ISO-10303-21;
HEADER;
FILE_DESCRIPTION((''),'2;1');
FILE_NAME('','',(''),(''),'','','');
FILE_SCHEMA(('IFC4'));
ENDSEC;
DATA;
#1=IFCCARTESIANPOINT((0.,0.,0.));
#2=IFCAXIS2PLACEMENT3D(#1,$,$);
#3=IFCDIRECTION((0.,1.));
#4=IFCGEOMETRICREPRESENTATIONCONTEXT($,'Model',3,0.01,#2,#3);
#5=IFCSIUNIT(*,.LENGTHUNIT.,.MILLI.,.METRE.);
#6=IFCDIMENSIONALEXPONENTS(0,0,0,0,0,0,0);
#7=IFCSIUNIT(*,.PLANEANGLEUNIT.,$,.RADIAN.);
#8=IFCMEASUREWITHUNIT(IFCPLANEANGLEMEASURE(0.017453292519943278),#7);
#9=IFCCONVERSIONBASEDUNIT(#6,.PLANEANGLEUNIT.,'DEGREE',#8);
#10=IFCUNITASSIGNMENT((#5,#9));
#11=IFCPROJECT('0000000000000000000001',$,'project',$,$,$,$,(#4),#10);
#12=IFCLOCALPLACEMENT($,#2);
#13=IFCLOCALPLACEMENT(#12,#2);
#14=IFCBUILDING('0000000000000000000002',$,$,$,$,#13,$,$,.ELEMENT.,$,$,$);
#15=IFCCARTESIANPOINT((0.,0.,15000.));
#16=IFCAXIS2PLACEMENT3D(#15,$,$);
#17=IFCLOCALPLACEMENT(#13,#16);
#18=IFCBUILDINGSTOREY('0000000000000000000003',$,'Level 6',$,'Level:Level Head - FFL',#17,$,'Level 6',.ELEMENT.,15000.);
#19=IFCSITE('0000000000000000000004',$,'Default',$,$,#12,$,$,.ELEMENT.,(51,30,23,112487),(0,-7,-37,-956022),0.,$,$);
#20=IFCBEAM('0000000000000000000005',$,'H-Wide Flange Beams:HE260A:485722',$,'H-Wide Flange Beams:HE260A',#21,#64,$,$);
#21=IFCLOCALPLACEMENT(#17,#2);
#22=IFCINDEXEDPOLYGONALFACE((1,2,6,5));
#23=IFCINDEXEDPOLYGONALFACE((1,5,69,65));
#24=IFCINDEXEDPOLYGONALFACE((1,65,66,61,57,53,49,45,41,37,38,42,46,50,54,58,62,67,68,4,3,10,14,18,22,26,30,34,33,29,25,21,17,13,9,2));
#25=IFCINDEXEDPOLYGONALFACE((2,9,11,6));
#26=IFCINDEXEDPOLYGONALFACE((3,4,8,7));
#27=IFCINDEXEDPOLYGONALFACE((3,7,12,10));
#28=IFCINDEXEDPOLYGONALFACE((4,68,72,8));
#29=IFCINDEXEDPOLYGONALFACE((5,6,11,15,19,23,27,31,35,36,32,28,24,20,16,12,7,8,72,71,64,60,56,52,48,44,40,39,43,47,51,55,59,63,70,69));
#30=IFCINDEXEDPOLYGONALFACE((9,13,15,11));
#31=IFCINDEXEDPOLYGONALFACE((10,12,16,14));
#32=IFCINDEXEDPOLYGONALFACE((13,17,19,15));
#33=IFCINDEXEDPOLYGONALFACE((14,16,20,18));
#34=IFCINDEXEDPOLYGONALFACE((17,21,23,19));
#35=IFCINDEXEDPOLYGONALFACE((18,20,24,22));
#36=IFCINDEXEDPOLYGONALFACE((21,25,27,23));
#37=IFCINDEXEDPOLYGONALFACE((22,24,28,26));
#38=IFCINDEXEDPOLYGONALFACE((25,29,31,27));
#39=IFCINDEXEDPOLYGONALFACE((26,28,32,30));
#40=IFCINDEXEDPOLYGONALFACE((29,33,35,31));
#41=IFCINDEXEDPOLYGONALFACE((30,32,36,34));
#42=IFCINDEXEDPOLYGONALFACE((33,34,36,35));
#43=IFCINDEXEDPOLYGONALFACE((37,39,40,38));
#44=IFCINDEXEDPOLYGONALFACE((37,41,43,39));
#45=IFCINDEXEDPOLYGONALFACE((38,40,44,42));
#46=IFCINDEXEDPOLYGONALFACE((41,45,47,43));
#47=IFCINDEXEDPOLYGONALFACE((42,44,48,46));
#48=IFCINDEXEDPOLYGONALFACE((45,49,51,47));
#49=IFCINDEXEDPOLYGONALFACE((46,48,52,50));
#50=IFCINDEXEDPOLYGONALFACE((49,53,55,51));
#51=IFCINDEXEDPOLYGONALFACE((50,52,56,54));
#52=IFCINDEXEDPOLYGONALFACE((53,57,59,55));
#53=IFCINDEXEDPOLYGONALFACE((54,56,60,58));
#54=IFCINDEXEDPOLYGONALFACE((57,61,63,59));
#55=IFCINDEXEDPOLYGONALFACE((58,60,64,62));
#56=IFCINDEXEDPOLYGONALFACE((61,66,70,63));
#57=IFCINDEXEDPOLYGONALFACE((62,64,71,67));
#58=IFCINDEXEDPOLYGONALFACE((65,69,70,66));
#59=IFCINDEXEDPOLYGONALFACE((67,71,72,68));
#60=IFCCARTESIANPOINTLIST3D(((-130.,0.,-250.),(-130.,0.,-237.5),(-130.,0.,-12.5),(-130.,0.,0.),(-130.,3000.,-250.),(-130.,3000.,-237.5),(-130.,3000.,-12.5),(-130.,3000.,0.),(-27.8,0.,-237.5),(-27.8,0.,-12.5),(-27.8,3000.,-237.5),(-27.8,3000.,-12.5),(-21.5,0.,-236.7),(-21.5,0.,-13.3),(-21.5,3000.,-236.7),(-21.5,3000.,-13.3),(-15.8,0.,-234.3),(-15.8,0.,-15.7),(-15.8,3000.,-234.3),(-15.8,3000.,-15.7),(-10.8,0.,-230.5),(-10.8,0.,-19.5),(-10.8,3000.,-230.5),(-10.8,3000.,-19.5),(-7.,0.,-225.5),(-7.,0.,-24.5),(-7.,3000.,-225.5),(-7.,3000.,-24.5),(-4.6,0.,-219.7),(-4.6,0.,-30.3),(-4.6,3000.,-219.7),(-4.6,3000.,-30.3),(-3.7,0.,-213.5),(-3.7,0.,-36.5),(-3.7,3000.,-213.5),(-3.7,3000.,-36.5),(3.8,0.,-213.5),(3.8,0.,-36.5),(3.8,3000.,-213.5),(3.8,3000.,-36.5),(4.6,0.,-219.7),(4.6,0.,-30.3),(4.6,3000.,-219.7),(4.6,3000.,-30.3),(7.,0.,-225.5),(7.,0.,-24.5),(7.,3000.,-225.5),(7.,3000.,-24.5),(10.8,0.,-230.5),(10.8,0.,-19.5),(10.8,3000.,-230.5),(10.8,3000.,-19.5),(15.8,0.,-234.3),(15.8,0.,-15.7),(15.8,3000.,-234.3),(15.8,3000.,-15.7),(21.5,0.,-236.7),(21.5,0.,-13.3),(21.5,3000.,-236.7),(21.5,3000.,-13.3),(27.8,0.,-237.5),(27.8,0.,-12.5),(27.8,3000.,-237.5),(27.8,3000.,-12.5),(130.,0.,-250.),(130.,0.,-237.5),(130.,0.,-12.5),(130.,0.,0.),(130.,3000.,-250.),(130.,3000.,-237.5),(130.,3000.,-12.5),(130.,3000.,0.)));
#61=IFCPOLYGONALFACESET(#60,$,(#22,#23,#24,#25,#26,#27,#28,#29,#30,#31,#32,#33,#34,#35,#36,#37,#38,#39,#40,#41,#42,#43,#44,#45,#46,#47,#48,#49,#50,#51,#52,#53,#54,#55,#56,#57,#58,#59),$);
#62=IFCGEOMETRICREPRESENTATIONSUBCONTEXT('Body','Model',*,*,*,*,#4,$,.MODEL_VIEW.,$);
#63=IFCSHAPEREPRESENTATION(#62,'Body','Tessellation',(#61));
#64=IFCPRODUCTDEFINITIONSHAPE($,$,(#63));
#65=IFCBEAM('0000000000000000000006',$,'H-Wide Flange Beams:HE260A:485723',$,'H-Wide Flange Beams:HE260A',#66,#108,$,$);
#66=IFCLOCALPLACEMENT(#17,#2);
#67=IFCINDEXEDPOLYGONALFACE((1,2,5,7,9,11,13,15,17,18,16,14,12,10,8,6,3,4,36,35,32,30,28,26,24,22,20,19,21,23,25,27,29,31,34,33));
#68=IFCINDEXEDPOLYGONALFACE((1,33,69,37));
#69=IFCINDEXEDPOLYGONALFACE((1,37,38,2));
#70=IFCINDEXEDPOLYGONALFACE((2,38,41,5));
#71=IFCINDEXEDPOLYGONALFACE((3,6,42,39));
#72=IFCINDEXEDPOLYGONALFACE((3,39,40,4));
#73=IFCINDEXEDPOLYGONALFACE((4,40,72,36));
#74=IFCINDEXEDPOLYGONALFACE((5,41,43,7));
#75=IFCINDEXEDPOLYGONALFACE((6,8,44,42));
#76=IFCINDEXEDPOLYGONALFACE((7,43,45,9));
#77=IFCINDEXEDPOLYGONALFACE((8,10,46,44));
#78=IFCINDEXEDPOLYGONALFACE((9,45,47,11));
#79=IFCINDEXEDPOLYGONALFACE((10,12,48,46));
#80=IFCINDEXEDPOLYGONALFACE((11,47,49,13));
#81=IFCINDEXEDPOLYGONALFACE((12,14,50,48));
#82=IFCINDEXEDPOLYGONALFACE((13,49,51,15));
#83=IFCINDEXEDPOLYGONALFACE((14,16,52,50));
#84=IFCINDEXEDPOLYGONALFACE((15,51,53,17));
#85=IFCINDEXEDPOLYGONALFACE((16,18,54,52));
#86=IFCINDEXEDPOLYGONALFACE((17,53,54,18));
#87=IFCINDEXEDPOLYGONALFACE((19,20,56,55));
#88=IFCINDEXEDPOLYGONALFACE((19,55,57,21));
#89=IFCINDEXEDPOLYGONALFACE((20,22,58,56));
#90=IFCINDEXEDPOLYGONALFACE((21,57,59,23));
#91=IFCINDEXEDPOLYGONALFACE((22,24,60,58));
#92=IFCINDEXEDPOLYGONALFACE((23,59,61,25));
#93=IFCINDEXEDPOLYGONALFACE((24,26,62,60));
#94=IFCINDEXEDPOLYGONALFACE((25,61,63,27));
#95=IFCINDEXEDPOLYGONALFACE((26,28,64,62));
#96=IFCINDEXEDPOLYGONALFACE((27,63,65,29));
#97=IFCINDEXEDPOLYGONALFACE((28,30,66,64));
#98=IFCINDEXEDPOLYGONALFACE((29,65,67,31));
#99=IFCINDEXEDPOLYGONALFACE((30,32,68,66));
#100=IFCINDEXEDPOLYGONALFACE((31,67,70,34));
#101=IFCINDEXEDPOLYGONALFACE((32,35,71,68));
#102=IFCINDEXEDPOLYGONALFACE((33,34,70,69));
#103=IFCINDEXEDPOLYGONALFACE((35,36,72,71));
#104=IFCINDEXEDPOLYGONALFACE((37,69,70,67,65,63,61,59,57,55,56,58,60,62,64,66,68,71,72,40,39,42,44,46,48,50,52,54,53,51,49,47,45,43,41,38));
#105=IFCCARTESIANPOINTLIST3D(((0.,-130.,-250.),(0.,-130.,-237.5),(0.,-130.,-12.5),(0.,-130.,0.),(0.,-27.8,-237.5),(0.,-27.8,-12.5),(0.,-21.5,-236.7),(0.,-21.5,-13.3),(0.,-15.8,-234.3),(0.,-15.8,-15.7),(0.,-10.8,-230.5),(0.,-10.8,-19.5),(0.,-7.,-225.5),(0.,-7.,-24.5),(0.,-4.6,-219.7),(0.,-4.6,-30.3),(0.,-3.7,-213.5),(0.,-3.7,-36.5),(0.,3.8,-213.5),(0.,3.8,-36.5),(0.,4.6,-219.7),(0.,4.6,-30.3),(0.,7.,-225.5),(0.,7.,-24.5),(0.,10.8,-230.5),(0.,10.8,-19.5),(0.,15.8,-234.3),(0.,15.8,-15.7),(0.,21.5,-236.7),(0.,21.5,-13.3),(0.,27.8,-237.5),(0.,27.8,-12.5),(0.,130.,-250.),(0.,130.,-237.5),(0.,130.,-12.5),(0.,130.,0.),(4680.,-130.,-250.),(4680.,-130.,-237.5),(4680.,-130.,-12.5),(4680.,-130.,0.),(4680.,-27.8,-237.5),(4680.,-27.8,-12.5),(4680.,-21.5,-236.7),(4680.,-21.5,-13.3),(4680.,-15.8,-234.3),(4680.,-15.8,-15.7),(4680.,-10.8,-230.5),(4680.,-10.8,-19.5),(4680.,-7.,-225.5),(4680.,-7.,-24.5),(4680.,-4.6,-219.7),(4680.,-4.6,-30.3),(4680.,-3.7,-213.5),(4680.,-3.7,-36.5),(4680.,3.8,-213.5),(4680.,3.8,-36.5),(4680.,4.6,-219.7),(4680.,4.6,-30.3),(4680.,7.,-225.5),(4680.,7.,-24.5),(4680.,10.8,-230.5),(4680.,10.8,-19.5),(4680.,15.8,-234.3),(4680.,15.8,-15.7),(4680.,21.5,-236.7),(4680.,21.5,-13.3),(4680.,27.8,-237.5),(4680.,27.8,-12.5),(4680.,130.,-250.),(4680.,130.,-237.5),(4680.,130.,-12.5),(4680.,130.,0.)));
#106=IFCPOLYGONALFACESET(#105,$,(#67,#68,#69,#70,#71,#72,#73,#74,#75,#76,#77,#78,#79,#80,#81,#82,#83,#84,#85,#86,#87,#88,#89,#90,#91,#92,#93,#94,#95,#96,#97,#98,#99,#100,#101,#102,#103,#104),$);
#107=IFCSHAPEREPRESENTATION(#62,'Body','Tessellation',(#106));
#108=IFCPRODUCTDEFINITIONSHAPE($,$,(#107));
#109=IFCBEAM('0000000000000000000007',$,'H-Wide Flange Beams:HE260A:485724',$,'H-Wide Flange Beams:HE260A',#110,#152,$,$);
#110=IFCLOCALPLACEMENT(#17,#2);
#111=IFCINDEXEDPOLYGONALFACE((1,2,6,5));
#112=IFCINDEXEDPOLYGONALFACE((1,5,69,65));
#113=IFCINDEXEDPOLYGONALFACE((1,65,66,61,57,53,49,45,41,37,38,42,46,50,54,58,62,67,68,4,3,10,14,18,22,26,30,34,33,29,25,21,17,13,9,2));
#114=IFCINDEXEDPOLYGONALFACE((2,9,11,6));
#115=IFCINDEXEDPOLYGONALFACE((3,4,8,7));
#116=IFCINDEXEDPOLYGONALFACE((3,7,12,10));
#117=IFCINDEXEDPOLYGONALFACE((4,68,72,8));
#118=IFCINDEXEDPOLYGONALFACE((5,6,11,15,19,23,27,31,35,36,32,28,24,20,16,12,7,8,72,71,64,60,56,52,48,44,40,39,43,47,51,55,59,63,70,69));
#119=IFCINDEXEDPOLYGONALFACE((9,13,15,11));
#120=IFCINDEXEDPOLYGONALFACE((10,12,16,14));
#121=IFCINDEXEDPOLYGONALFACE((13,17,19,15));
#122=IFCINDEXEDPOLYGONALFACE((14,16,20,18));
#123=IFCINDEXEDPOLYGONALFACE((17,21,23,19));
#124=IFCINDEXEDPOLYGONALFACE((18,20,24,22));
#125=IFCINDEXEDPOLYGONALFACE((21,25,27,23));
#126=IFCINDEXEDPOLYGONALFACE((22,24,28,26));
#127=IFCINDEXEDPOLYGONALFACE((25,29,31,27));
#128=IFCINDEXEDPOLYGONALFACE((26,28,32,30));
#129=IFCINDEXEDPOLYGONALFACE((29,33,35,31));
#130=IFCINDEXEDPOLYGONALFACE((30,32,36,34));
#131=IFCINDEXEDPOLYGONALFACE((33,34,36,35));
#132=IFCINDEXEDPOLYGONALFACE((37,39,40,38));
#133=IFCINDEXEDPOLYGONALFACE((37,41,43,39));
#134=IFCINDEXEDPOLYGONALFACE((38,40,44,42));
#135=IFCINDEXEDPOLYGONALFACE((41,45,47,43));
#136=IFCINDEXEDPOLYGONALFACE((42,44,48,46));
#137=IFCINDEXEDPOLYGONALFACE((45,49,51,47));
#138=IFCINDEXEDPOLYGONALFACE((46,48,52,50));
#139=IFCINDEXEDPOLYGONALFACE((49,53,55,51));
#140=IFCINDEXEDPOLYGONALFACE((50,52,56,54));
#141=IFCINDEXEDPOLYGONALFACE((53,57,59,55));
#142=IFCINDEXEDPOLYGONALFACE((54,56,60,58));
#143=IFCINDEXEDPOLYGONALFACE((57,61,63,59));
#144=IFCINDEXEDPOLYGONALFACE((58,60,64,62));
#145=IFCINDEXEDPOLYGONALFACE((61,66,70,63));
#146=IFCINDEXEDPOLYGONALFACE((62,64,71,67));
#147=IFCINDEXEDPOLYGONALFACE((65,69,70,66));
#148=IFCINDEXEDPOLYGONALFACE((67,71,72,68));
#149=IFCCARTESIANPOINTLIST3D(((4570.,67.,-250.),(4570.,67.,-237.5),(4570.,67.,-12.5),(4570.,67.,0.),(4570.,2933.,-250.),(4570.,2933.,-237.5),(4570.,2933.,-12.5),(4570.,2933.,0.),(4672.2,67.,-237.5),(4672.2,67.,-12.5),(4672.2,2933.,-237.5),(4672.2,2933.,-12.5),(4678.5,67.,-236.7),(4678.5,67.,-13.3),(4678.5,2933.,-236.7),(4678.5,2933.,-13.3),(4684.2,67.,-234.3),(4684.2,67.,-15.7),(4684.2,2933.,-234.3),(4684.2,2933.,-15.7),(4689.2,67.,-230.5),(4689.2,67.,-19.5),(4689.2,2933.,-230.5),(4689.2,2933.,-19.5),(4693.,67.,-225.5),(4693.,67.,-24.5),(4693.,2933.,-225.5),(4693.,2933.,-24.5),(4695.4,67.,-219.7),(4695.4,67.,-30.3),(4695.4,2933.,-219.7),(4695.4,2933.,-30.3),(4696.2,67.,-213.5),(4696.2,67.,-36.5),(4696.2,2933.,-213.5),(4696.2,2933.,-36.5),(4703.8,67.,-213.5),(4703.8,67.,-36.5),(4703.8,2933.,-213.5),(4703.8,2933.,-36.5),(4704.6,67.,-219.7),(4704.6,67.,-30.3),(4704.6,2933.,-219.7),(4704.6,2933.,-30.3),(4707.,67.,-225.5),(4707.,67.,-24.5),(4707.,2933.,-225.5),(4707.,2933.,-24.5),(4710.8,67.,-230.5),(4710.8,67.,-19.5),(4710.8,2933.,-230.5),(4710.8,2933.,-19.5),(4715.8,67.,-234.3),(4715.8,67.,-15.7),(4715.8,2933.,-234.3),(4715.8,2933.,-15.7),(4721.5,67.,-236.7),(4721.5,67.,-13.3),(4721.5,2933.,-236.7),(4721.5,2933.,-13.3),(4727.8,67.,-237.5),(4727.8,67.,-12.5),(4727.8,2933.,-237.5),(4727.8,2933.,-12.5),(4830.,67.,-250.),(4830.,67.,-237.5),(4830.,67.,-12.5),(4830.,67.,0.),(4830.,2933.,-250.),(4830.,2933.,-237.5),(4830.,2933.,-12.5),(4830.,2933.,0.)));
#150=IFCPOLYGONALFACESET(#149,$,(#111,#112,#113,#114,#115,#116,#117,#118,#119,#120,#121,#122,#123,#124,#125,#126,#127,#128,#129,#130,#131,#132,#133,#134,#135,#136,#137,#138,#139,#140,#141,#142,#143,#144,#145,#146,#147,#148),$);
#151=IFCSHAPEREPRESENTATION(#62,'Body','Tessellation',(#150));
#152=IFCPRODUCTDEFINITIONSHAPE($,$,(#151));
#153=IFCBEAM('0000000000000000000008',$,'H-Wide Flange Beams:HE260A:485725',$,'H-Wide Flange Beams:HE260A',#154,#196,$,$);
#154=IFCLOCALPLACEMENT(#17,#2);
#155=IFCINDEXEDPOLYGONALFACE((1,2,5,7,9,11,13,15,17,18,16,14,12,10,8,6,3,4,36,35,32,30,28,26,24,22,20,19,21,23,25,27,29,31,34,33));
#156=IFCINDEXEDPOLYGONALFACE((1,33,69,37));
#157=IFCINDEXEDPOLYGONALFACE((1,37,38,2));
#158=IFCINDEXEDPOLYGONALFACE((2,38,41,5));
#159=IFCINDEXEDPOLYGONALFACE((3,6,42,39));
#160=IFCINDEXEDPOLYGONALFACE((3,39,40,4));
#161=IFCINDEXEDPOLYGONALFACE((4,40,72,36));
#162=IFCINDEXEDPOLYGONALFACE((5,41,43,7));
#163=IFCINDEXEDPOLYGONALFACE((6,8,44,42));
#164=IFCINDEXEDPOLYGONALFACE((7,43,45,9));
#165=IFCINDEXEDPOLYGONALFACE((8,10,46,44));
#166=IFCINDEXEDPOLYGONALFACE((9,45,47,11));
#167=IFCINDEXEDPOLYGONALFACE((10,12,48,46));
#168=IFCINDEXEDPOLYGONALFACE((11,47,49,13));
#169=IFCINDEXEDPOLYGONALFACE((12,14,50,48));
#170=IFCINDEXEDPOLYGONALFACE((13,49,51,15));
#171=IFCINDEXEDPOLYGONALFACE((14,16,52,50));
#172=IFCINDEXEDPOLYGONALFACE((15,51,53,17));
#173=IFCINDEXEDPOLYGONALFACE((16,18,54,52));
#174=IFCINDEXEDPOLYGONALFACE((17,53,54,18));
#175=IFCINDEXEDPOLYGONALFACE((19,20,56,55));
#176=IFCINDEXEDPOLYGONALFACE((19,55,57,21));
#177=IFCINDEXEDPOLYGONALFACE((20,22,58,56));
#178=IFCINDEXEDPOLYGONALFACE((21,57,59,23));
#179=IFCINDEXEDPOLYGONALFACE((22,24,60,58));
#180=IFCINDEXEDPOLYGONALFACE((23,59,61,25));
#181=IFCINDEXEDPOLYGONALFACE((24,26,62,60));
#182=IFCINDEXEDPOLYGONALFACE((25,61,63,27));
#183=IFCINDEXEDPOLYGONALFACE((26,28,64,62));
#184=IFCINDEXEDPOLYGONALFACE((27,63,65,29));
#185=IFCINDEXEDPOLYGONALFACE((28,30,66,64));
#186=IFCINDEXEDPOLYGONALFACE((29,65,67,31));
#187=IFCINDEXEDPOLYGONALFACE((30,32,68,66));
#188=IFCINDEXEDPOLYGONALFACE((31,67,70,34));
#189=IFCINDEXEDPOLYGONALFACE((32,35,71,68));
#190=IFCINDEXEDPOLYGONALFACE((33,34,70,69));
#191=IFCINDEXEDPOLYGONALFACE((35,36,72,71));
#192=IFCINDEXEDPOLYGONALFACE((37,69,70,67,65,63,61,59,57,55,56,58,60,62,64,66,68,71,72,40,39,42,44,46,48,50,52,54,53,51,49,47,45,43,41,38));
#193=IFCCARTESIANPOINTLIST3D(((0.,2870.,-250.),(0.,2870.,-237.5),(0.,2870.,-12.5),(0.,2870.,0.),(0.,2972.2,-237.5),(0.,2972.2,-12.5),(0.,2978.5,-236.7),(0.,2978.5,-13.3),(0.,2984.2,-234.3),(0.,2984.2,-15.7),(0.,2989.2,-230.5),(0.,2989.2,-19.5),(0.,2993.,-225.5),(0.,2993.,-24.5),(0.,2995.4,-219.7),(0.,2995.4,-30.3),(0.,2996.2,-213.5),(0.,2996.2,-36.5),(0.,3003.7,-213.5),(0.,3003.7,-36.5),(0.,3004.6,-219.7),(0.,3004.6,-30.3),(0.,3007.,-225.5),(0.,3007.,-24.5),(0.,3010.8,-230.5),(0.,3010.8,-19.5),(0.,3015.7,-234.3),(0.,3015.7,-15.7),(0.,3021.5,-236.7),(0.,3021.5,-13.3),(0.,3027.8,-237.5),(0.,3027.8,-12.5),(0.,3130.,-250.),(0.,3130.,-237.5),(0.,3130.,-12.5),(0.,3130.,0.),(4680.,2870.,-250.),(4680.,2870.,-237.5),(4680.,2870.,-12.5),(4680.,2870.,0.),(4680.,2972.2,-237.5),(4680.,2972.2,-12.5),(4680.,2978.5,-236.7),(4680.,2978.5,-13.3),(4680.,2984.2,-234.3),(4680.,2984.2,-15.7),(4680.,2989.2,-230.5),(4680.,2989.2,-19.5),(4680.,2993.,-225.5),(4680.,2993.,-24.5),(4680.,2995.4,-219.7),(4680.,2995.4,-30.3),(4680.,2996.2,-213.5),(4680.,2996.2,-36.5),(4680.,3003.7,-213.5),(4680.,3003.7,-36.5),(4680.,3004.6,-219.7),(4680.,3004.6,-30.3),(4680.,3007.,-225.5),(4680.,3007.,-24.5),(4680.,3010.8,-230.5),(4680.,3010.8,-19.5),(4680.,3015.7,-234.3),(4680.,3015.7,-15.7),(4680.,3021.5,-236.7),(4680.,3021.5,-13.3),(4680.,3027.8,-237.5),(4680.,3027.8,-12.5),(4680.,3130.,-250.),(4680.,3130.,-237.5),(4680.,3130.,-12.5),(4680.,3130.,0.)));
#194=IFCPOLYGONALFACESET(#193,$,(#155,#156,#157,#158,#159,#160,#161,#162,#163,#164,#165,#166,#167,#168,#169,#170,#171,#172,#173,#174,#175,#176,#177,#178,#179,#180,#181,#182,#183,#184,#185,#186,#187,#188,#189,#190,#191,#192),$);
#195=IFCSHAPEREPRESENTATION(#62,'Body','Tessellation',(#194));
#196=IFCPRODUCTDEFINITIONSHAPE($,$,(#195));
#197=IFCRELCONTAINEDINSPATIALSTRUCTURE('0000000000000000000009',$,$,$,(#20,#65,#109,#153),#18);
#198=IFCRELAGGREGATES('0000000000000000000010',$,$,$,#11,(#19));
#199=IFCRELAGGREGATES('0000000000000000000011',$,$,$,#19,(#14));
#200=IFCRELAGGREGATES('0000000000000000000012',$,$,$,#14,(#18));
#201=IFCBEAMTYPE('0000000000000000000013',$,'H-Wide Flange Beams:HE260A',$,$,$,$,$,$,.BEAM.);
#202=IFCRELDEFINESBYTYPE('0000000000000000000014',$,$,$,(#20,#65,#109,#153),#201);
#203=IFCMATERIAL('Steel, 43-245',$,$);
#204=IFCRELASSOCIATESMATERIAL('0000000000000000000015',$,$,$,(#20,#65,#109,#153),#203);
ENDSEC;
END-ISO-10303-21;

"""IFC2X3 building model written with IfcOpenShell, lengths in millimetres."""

from ifc_helpers import new_model, entity, si_unit, converted_unit, direction, frame, frame_2d, origin, place, context, subcontext, project, spatial, i_section, extrude, material, type_object, element, save


model = new_model("IFC2X3")

# Units and contexts
model_context = context("Model", 3, precision=0.01, world=origin(), true_north=direction((0.0, 1.0)))
body_context = subcontext(model_context, "Body", "Model", "MODEL_VIEW")
ifc_project = project(units=[si_unit("LENGTHUNIT", "METRE", prefix="MILLI"), converted_unit("PLANEANGLEUNIT", "DEGREE", entity("IfcPlaneAngleMeasure", 0.017453292519943278), si_unit("PLANEANGLEUNIT", "RADIAN"), dimensions=[0, 0, 0, 0, 0, 0, 0])], contexts=[model_context])

# Site, building, storey
site_placement = place(None, origin())
site = spatial("IfcSite", under=ifc_project, at=site_placement, Name="Default", CompositionType="ELEMENT", RefLatitude=(51, 30, 23, 112487), RefLongitude=(0, -7, -37, -956022), RefElevation=0.0)
building_placement = place(site_placement, origin())
building = spatial("IfcBuilding", under=site, at=building_placement, CompositionType="ELEMENT")
storey_placement = place(building_placement, frame((0.0, 0.0, 15000.0)))
storey = spatial("IfcBuildingStorey", under=building, at=storey_placement, Name="Level 6", ObjectType="Level:Level Head - FFL", LongName="Level 6", CompositionType="ELEMENT", Elevation=15000.0)

# Beams
ifc_material = material(Name="Steel, 43-245")
beam_type_1 = type_object("IfcBeamType", Name="H-Wide Flange Beams:HE260A", PredefinedType="BEAM")
beam_1_placement = place(storey_placement, frame((0.0, 3000.0, 0.0), z_axis=(0.0, 0.0, 1.0), x_axis=(0.0, -1.0, 0.0)))
element("IfcBeam", 1, at=beam_1_placement, inside=storey, type_object=beam_type_1, material=ifc_material, Name="H-Wide Flange Beams:HE260A:485722", ObjectType="H-Wide Flange Beams:HE260A", context=body_context, shape_type="SweptSolid", body=[
    extrude(i_section(OverallWidth=260.0, OverallDepth=250.0, WebThickness=7.5, FlangeThickness=12.5, FilletRadius=24.0, at=frame_2d((0.0, 0.0), x_axis=(0.0, 1.0))), frame((0.0, 0.0, -125.0), z_axis=(1.0, 0.0, 0.0), x_axis=(0.0, 0.0, -1.0)), (0.0, 0.0, 1.0), 3000.0),
])
beam_2_placement = place(storey_placement, origin())
element("IfcBeam", 2, at=beam_2_placement, inside=storey, type_object=beam_type_1, material=ifc_material, Name="H-Wide Flange Beams:HE260A:485723", ObjectType="H-Wide Flange Beams:HE260A", context=body_context, shape_type="SweptSolid", body=[
    extrude(i_section(OverallWidth=260.0, OverallDepth=250.0, WebThickness=7.5, FlangeThickness=12.5, FilletRadius=24.0, at=frame_2d((0.0, 0.0), x_axis=(0.0, 1.0))), frame((0.0, 0.0, -125.0), z_axis=(1.0, 0.0, 0.0), x_axis=(0.0, 0.0, -1.0)), (0.0, 0.0, 1.0), 4680.0),
])
beam_3_placement = place(storey_placement, frame((4700.0, 0.0, 0.0), z_axis=(0.0, 0.0, 1.0), x_axis=(0.0, 1.0, 0.0)))
element("IfcBeam", 3, at=beam_3_placement, inside=storey, type_object=beam_type_1, material=ifc_material, Name="H-Wide Flange Beams:HE260A:485724", ObjectType="H-Wide Flange Beams:HE260A", context=body_context, shape_type="SweptSolid", body=[
    extrude(i_section(OverallWidth=260.0, OverallDepth=250.0, WebThickness=7.5, FlangeThickness=12.5, FilletRadius=24.0, at=frame_2d((0.0, 0.0), x_axis=(0.0, 1.0))), frame((67.0, 0.0, -125.0), z_axis=(1.0, 0.0, 0.0), x_axis=(0.0, 0.0, -1.0)), (0.0, 0.0, 1.0), 2866.0),
])
beam_4_placement = place(storey_placement, frame((4700.0, 3000.0, 0.0), z_axis=(0.0, 0.0, 1.0), x_axis=(-1.0, 0.0, 0.0)))
element("IfcBeam", 4, at=beam_4_placement, inside=storey, type_object=beam_type_1, material=ifc_material, Name="H-Wide Flange Beams:HE260A:485725", ObjectType="H-Wide Flange Beams:HE260A", context=body_context, shape_type="SweptSolid", body=[
    extrude(i_section(OverallWidth=260.0, OverallDepth=250.0, WebThickness=7.5, FlangeThickness=12.5, FilletRadius=24.0, at=frame_2d((0.0, 0.0), x_axis=(0.0, 1.0))), frame((20.0, 0.0, -125.0), z_axis=(1.0, 0.0, 0.0), x_axis=(0.0, 0.0, -1.0)), (0.0, 0.0, 1.0), 4680.0),
])

save(model, "model.ifc")
